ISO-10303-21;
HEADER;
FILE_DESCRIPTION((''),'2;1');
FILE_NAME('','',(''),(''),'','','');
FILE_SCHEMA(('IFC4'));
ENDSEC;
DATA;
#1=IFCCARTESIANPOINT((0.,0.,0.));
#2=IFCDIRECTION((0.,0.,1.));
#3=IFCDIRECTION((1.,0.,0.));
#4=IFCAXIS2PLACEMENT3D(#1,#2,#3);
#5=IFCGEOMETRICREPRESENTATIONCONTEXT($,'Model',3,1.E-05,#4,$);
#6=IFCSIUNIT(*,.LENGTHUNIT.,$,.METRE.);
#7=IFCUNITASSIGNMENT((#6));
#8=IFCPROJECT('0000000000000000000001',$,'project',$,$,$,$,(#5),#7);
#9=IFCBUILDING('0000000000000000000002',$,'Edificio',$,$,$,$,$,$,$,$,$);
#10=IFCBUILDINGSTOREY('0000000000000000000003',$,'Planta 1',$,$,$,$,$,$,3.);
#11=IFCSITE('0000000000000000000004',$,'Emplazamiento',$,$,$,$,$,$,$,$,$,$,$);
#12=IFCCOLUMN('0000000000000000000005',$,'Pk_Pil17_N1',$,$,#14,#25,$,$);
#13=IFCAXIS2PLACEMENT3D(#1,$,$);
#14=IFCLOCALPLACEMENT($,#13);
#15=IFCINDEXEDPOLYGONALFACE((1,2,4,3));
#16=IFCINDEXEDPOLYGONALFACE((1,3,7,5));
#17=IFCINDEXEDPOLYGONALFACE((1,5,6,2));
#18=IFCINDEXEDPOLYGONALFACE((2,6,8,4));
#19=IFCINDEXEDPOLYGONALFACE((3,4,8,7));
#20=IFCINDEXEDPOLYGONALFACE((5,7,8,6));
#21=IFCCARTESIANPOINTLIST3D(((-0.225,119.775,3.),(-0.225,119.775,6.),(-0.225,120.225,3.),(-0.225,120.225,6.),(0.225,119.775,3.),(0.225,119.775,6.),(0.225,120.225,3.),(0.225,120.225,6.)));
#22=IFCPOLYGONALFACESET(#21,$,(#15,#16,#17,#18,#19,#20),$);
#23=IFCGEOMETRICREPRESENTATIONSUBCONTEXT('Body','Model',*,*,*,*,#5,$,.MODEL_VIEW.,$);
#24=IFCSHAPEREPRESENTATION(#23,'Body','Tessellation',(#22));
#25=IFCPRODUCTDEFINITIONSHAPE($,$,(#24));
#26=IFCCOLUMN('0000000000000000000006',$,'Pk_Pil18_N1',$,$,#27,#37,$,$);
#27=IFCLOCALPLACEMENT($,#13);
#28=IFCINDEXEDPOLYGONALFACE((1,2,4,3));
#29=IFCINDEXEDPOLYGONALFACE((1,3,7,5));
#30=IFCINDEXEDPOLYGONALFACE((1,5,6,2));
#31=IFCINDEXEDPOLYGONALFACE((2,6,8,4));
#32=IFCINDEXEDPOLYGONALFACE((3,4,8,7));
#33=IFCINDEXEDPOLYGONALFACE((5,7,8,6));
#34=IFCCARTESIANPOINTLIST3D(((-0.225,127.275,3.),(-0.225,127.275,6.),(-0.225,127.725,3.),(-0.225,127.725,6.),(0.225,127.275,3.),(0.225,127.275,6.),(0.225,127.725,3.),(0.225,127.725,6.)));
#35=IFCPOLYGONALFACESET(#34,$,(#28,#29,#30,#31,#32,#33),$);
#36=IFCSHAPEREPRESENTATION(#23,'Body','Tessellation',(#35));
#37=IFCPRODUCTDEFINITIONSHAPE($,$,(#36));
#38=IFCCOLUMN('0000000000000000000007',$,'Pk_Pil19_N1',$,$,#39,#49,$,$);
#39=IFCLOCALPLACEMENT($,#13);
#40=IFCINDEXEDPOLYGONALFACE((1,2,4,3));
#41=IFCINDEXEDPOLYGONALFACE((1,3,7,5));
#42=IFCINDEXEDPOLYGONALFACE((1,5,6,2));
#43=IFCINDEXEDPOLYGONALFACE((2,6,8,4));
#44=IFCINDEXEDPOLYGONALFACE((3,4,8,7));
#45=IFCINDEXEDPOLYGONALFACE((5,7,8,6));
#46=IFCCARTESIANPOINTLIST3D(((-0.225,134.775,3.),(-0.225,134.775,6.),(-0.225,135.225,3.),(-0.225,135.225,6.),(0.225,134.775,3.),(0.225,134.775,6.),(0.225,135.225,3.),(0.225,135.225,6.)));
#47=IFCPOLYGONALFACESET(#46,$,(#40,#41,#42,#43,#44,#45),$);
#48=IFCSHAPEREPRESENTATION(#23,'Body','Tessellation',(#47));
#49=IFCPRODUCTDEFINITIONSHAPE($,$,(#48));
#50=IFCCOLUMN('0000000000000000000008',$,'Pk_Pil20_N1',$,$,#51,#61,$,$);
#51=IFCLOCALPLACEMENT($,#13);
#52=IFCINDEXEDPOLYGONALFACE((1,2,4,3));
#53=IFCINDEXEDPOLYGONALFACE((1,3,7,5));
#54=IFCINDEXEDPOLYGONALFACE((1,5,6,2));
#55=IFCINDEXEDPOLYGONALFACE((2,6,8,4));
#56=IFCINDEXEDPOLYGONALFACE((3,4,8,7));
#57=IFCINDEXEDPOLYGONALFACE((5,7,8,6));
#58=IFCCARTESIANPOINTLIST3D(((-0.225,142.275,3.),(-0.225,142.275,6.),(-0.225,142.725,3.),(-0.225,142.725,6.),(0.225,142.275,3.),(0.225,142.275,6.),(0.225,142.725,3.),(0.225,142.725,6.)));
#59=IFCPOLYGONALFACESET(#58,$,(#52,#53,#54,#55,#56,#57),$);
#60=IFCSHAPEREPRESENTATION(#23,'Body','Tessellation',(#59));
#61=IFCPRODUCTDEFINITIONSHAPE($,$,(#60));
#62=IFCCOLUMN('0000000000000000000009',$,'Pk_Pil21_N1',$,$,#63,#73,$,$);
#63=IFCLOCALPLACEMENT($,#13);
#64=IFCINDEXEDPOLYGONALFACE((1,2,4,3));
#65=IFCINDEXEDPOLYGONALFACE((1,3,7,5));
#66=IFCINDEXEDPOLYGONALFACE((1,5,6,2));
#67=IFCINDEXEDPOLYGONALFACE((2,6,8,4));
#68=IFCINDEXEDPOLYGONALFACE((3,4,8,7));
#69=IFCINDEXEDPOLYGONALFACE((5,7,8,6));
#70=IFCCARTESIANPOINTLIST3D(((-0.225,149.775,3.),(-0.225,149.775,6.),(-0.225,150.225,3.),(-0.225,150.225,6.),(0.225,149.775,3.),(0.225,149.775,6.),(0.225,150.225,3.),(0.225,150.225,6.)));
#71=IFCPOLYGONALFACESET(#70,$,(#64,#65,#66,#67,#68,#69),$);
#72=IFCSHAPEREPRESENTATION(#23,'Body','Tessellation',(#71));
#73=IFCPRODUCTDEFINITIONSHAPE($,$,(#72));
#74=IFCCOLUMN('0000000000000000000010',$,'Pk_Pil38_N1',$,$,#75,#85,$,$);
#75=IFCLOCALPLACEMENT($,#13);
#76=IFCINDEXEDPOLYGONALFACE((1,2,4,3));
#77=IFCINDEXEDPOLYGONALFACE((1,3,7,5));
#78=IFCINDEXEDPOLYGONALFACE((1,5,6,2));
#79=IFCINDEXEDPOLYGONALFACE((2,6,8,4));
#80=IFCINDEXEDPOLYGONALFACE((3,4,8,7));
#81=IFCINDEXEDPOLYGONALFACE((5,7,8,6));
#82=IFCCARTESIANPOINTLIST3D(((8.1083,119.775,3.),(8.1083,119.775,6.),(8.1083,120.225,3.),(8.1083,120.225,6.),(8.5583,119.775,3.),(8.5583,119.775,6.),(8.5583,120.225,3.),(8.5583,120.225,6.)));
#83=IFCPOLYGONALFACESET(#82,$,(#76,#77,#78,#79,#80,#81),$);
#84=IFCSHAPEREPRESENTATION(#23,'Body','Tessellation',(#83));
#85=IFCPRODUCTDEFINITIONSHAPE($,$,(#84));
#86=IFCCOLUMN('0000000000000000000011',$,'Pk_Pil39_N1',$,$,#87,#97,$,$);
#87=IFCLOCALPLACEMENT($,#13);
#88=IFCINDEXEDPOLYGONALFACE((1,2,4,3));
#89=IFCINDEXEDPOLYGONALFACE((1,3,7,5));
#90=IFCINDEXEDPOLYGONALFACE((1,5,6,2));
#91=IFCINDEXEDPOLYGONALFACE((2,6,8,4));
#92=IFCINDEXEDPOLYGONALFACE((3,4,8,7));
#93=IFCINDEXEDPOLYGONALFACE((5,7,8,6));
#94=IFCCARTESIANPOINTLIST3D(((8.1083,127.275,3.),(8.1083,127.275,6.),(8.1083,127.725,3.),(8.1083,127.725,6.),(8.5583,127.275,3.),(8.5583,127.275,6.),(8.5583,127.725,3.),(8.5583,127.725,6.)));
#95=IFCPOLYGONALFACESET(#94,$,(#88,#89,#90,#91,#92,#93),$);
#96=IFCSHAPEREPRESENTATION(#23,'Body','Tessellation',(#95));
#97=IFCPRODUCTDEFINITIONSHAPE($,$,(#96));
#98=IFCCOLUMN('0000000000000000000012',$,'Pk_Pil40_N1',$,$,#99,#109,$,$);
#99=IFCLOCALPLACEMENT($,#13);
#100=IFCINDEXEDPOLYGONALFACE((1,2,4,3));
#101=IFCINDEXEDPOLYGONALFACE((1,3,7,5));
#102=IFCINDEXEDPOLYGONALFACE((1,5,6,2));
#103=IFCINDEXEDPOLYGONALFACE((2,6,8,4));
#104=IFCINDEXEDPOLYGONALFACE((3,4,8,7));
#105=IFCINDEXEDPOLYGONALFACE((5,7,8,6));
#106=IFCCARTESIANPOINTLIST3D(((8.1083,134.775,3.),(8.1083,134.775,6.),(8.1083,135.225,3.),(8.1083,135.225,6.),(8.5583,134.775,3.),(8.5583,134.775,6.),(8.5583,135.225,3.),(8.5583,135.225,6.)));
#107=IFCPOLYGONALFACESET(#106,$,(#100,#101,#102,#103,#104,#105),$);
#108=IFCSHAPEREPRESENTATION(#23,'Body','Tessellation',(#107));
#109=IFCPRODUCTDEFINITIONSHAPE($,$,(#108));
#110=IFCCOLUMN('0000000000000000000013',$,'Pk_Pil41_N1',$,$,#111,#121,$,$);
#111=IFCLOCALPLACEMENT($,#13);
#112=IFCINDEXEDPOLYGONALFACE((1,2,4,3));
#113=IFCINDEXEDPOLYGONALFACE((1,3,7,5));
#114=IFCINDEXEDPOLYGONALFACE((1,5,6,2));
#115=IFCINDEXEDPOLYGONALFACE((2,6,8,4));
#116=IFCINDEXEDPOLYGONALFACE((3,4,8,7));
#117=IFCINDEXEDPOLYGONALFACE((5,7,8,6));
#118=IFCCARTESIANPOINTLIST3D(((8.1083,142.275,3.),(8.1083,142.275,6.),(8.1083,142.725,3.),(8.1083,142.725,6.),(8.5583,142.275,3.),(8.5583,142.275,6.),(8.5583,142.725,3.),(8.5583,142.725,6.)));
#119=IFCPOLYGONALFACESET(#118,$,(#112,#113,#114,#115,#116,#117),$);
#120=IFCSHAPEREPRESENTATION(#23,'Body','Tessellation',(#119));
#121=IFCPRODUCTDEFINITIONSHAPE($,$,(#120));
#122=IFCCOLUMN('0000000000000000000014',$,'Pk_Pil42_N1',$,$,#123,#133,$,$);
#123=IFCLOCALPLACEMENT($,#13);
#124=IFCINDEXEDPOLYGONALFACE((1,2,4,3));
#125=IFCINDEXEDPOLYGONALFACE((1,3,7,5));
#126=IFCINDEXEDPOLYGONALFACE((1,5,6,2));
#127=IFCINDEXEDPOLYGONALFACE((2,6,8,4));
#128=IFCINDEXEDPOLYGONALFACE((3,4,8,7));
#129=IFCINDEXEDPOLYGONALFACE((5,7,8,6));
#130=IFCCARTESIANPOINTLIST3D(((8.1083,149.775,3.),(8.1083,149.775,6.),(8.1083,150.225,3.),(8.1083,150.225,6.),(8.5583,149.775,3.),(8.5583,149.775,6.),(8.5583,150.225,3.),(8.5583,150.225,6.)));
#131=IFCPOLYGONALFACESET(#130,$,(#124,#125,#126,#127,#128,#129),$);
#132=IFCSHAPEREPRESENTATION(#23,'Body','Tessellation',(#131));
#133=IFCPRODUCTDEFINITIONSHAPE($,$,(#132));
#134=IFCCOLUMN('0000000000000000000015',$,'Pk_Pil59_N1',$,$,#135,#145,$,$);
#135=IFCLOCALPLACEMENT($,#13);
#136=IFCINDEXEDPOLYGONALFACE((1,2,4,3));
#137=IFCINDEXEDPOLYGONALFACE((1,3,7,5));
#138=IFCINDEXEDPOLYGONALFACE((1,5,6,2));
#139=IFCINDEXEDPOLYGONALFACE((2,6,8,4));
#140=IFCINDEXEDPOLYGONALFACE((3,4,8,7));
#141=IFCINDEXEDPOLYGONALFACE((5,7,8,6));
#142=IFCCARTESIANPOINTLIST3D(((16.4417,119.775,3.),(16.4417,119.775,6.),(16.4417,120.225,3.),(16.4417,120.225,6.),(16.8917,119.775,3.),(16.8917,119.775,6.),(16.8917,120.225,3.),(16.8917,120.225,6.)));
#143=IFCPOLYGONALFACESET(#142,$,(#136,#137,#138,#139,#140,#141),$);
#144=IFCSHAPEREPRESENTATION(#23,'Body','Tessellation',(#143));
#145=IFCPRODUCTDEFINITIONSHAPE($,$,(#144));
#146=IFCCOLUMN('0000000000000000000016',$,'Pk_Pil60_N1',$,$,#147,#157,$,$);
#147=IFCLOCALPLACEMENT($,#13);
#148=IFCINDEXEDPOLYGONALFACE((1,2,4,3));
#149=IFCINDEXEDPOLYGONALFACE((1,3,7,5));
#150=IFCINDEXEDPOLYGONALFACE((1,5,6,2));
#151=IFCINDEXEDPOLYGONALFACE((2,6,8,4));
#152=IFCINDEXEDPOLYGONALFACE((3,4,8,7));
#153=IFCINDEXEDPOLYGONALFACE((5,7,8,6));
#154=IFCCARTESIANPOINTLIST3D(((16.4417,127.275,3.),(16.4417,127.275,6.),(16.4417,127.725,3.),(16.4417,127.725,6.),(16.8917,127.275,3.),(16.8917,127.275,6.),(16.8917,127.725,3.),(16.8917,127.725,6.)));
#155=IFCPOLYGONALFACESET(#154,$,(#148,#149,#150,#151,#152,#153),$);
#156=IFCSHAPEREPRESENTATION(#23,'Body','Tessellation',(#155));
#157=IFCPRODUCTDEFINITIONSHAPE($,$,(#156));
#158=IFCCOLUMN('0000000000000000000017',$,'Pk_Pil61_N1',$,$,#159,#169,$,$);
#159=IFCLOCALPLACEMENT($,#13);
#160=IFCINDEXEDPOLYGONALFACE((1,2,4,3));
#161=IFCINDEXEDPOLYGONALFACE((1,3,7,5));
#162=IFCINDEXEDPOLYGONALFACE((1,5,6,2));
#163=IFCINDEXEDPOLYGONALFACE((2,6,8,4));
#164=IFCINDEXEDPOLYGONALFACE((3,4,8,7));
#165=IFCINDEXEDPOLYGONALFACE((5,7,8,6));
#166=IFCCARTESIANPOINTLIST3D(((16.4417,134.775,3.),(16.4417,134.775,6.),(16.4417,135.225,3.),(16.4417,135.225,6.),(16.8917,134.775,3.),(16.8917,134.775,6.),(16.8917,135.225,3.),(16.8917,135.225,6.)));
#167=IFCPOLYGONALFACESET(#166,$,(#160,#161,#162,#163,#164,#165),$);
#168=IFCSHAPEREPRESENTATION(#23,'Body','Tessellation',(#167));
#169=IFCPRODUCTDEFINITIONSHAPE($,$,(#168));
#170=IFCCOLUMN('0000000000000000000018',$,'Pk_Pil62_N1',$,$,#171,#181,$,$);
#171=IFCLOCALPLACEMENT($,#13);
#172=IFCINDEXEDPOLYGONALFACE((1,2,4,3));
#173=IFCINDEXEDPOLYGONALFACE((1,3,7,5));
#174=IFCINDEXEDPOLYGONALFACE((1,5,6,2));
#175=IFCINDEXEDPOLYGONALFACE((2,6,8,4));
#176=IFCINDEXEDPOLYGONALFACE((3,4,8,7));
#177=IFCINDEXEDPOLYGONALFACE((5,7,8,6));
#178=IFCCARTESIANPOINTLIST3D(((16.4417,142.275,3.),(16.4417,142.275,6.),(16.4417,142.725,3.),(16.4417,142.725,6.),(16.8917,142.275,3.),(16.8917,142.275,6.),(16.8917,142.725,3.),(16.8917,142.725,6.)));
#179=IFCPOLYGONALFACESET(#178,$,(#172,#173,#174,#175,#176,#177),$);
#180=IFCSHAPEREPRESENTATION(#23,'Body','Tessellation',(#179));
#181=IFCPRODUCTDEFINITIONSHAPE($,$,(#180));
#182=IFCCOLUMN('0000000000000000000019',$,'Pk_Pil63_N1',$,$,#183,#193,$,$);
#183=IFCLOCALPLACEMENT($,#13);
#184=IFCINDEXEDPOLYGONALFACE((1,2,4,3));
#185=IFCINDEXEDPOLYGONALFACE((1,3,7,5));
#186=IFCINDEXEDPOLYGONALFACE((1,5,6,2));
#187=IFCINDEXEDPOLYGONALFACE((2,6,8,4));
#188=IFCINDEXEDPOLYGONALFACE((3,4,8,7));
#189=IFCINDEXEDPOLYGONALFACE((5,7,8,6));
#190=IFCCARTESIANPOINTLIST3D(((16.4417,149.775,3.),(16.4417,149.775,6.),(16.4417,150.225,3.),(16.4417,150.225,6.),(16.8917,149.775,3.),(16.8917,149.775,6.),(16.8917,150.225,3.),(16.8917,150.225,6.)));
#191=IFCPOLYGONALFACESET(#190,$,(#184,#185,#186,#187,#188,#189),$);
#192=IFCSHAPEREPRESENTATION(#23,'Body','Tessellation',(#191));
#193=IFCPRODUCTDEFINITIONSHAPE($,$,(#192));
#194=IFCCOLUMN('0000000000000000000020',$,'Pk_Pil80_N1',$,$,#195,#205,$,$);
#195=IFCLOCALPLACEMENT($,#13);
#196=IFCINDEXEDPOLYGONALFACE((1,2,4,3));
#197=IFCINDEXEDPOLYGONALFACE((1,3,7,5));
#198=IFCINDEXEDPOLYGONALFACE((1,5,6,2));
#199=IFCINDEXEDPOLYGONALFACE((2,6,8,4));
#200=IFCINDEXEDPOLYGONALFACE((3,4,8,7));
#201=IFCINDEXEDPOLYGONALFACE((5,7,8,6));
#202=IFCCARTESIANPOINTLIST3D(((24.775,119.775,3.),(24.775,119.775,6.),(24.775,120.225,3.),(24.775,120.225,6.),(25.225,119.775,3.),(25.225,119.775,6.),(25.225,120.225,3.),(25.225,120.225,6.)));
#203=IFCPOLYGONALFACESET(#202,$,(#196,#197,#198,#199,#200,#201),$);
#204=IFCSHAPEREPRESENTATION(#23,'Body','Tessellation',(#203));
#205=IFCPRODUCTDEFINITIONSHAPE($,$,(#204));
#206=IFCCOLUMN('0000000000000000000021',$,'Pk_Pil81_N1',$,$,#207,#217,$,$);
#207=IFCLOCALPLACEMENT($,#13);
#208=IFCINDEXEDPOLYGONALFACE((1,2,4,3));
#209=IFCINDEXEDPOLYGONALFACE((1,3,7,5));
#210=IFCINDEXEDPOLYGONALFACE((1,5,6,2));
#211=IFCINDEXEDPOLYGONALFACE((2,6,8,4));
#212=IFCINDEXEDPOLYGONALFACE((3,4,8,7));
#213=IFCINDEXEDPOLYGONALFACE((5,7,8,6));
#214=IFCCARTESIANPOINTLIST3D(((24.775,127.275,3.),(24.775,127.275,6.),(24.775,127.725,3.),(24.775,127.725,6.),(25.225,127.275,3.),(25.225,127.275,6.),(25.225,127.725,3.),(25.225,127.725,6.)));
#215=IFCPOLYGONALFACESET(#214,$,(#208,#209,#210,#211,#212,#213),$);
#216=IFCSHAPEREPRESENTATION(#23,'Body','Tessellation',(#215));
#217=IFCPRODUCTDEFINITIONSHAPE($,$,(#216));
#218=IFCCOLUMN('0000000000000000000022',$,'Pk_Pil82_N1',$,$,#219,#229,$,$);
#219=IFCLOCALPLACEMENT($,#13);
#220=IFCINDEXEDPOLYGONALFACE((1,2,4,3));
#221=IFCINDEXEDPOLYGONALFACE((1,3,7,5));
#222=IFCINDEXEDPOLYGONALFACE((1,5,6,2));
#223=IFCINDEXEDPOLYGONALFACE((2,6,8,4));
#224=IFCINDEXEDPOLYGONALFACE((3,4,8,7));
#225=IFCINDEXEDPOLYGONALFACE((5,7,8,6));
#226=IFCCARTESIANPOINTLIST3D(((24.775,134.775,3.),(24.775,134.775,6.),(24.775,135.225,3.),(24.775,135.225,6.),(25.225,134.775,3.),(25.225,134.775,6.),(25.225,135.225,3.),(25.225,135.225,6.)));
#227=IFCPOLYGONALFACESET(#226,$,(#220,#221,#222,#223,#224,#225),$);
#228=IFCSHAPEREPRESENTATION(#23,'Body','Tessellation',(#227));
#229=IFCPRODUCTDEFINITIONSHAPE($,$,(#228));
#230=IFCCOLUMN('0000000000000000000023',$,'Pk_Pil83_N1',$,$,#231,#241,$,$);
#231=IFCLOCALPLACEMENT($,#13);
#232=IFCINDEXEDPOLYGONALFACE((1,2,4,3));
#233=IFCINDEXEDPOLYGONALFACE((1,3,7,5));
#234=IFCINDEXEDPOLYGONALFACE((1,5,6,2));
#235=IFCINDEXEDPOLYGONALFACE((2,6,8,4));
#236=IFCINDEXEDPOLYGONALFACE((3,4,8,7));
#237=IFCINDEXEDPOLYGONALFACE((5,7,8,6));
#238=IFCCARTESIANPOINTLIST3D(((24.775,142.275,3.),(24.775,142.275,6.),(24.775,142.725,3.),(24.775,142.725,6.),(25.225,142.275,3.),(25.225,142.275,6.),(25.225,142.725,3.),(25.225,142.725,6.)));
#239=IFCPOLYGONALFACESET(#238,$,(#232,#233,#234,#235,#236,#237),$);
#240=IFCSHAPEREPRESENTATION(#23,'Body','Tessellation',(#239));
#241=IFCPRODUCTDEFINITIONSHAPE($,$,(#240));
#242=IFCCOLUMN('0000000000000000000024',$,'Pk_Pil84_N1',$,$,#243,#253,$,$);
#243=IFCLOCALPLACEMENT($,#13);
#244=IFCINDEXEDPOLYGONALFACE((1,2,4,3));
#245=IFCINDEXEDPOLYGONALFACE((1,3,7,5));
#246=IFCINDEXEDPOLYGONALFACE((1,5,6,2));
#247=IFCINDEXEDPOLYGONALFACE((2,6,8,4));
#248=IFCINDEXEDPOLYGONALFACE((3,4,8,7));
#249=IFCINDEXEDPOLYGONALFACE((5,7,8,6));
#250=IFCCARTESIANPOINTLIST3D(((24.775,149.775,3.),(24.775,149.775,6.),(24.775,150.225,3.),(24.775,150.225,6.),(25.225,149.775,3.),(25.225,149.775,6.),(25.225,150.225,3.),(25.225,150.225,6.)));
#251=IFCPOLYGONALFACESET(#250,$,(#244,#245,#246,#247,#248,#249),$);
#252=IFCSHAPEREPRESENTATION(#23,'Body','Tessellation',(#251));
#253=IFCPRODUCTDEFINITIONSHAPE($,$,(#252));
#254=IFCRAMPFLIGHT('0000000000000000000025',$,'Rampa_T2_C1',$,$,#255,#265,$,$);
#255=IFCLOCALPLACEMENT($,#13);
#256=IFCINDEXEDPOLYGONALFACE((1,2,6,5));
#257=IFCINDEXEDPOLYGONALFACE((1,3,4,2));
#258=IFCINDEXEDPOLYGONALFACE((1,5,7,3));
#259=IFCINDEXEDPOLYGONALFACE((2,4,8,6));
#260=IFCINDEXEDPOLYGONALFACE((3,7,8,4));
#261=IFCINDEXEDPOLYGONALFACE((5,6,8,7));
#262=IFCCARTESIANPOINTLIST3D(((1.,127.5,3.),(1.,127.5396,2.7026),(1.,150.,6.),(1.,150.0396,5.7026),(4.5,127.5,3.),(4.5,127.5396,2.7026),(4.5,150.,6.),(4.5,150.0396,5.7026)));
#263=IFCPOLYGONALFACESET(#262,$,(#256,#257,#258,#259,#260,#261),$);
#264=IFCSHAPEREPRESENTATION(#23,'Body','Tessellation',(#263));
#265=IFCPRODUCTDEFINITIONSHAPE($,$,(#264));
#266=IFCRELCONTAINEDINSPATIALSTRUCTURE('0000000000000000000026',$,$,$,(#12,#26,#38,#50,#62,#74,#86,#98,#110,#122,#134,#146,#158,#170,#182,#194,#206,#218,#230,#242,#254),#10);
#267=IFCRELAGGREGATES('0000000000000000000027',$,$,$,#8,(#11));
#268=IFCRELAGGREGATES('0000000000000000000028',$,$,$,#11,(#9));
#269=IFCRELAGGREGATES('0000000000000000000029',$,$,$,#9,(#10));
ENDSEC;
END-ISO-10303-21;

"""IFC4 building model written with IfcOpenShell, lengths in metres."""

from ifc_helpers import new_model, si_unit, frame, origin_with_axes, origin_2d, place, context, subcontext, project, spatial, rectangle, extrude, element, save


model = new_model("IFC4")

# Units and contexts
model_context = context("Model", 3, precision=1e-05, world=origin_with_axes())
body_context = subcontext(model_context, "Body", "Model", "MODEL_VIEW")
ifc_project = project(units=[si_unit("LENGTHUNIT", "METRE")], contexts=[model_context])

# Site, building, storey
site = spatial("IfcSite", under=ifc_project, Name="Emplazamiento")
building = spatial("IfcBuilding", under=site, Name="Edificio")
storey = spatial("IfcBuildingStorey", under=building, Name="Planta 1", Elevation=3.0)

# Columns
for number, where, z_axis, x_axis, name in (
    (1, (0.0, 120.0, 3.0), (0.0, 0.0, 1.0), (1.0, 0.0, 0.0), "Pk_Pil17_N1"),
    (2, (0.0, 127.5, 3.0), (0.0, 0.0, 1.0), (1.0, 0.0, 0.0), "Pk_Pil18_N1"),
    (3, (0.0, 135.0, 3.0), (0.0, 0.0, 1.0), (1.0, 0.0, 0.0), "Pk_Pil19_N1"),
    (4, (0.0, 142.5, 3.0), (0.0, 0.0, 1.0), (1.0, 0.0, 0.0), "Pk_Pil20_N1"),
    (5, (0.0, 150.0, 3.0), (0.0, 0.0, 1.0), (1.0, 0.0, 0.0), "Pk_Pil21_N1"),
    (6, (8.3333, 120.0, 3.0), (0.0, 0.0, 1.0), (1.0, 0.0, 0.0), "Pk_Pil38_N1"),
    (7, (8.3333, 127.5, 3.0), (0.0, 0.0, 1.0), (1.0, 0.0, 0.0), "Pk_Pil39_N1"),
    (8, (8.3333, 135.0, 3.0), (0.0, 0.0, 1.0), (1.0, 0.0, 0.0), "Pk_Pil40_N1"),
    (9, (8.3333, 142.5, 3.0), (0.0, 0.0, 1.0), (1.0, 0.0, 0.0), "Pk_Pil41_N1"),
    (10, (8.3333, 150.0, 3.0), (0.0, 0.0, 1.0), (1.0, 0.0, 0.0), "Pk_Pil42_N1"),
    (11, (16.6667, 120.0, 3.0), (0.0, 0.0, 1.0), (1.0, 0.0, 0.0), "Pk_Pil59_N1"),
    (12, (16.6667, 127.5, 3.0), (0.0, 0.0, 1.0), (1.0, 0.0, 0.0), "Pk_Pil60_N1"),
    (13, (16.6667, 135.0, 3.0), (0.0, 0.0, 1.0), (1.0, 0.0, 0.0), "Pk_Pil61_N1"),
    (14, (16.6667, 142.5, 3.0), (0.0, 0.0, 1.0), (1.0, 0.0, 0.0), "Pk_Pil62_N1"),
    (15, (16.6667, 150.0, 3.0), (0.0, 0.0, 1.0), (1.0, 0.0, 0.0), "Pk_Pil63_N1"),
    (16, (25.0, 120.0, 3.0), (0.0, 0.0, 1.0), (1.0, 0.0, 0.0), "Pk_Pil80_N1"),
    (17, (25.0, 127.5, 3.0), (0.0, 0.0, 1.0), (1.0, 0.0, 0.0), "Pk_Pil81_N1"),
    (18, (25.0, 135.0, 3.0), (0.0, 0.0, 1.0), (1.0, 0.0, 0.0), "Pk_Pil82_N1"),
    (19, (25.0, 142.5, 3.0), (0.0, 0.0, 1.0), (1.0, 0.0, 0.0), "Pk_Pil83_N1"),
    (20, (25.0, 150.0, 3.0), (0.0, 0.0, 1.0), (1.0, 0.0, 0.0), "Pk_Pil84_N1"),
):
    element("IfcColumn", number, at=place(None, frame(where, z_axis=z_axis, x_axis=x_axis)), inside=storey, Name=name, context=body_context, shape_type="SweptSolid", body=[
        extrude(rectangle(XDim=0.45, YDim=0.45, at=origin_2d()), origin_with_axes(), (0.0, 0.0, 1.0), 3.0),
    ])

# Ramp flight
for number, where, z_axis, x_axis, name in (
    (21, (2.75, 138.7896, 4.2026), (0.0, -0.132164, 0.991228), (0.0, 0.991228, 0.132164), "Rampa_T2_C1"),
):
    element("IfcRampFlight", number, at=place(None, frame(where, z_axis=z_axis, x_axis=x_axis)), inside=storey, Name=name, context=body_context, shape_type="SweptSolid", body=[
        extrude(rectangle(XDim=22.6991, YDim=3.5, at=origin_2d()), origin_with_axes(), (0.0, 0.0, 1.0), 0.3),
    ])

save(model, "model.ifc")
